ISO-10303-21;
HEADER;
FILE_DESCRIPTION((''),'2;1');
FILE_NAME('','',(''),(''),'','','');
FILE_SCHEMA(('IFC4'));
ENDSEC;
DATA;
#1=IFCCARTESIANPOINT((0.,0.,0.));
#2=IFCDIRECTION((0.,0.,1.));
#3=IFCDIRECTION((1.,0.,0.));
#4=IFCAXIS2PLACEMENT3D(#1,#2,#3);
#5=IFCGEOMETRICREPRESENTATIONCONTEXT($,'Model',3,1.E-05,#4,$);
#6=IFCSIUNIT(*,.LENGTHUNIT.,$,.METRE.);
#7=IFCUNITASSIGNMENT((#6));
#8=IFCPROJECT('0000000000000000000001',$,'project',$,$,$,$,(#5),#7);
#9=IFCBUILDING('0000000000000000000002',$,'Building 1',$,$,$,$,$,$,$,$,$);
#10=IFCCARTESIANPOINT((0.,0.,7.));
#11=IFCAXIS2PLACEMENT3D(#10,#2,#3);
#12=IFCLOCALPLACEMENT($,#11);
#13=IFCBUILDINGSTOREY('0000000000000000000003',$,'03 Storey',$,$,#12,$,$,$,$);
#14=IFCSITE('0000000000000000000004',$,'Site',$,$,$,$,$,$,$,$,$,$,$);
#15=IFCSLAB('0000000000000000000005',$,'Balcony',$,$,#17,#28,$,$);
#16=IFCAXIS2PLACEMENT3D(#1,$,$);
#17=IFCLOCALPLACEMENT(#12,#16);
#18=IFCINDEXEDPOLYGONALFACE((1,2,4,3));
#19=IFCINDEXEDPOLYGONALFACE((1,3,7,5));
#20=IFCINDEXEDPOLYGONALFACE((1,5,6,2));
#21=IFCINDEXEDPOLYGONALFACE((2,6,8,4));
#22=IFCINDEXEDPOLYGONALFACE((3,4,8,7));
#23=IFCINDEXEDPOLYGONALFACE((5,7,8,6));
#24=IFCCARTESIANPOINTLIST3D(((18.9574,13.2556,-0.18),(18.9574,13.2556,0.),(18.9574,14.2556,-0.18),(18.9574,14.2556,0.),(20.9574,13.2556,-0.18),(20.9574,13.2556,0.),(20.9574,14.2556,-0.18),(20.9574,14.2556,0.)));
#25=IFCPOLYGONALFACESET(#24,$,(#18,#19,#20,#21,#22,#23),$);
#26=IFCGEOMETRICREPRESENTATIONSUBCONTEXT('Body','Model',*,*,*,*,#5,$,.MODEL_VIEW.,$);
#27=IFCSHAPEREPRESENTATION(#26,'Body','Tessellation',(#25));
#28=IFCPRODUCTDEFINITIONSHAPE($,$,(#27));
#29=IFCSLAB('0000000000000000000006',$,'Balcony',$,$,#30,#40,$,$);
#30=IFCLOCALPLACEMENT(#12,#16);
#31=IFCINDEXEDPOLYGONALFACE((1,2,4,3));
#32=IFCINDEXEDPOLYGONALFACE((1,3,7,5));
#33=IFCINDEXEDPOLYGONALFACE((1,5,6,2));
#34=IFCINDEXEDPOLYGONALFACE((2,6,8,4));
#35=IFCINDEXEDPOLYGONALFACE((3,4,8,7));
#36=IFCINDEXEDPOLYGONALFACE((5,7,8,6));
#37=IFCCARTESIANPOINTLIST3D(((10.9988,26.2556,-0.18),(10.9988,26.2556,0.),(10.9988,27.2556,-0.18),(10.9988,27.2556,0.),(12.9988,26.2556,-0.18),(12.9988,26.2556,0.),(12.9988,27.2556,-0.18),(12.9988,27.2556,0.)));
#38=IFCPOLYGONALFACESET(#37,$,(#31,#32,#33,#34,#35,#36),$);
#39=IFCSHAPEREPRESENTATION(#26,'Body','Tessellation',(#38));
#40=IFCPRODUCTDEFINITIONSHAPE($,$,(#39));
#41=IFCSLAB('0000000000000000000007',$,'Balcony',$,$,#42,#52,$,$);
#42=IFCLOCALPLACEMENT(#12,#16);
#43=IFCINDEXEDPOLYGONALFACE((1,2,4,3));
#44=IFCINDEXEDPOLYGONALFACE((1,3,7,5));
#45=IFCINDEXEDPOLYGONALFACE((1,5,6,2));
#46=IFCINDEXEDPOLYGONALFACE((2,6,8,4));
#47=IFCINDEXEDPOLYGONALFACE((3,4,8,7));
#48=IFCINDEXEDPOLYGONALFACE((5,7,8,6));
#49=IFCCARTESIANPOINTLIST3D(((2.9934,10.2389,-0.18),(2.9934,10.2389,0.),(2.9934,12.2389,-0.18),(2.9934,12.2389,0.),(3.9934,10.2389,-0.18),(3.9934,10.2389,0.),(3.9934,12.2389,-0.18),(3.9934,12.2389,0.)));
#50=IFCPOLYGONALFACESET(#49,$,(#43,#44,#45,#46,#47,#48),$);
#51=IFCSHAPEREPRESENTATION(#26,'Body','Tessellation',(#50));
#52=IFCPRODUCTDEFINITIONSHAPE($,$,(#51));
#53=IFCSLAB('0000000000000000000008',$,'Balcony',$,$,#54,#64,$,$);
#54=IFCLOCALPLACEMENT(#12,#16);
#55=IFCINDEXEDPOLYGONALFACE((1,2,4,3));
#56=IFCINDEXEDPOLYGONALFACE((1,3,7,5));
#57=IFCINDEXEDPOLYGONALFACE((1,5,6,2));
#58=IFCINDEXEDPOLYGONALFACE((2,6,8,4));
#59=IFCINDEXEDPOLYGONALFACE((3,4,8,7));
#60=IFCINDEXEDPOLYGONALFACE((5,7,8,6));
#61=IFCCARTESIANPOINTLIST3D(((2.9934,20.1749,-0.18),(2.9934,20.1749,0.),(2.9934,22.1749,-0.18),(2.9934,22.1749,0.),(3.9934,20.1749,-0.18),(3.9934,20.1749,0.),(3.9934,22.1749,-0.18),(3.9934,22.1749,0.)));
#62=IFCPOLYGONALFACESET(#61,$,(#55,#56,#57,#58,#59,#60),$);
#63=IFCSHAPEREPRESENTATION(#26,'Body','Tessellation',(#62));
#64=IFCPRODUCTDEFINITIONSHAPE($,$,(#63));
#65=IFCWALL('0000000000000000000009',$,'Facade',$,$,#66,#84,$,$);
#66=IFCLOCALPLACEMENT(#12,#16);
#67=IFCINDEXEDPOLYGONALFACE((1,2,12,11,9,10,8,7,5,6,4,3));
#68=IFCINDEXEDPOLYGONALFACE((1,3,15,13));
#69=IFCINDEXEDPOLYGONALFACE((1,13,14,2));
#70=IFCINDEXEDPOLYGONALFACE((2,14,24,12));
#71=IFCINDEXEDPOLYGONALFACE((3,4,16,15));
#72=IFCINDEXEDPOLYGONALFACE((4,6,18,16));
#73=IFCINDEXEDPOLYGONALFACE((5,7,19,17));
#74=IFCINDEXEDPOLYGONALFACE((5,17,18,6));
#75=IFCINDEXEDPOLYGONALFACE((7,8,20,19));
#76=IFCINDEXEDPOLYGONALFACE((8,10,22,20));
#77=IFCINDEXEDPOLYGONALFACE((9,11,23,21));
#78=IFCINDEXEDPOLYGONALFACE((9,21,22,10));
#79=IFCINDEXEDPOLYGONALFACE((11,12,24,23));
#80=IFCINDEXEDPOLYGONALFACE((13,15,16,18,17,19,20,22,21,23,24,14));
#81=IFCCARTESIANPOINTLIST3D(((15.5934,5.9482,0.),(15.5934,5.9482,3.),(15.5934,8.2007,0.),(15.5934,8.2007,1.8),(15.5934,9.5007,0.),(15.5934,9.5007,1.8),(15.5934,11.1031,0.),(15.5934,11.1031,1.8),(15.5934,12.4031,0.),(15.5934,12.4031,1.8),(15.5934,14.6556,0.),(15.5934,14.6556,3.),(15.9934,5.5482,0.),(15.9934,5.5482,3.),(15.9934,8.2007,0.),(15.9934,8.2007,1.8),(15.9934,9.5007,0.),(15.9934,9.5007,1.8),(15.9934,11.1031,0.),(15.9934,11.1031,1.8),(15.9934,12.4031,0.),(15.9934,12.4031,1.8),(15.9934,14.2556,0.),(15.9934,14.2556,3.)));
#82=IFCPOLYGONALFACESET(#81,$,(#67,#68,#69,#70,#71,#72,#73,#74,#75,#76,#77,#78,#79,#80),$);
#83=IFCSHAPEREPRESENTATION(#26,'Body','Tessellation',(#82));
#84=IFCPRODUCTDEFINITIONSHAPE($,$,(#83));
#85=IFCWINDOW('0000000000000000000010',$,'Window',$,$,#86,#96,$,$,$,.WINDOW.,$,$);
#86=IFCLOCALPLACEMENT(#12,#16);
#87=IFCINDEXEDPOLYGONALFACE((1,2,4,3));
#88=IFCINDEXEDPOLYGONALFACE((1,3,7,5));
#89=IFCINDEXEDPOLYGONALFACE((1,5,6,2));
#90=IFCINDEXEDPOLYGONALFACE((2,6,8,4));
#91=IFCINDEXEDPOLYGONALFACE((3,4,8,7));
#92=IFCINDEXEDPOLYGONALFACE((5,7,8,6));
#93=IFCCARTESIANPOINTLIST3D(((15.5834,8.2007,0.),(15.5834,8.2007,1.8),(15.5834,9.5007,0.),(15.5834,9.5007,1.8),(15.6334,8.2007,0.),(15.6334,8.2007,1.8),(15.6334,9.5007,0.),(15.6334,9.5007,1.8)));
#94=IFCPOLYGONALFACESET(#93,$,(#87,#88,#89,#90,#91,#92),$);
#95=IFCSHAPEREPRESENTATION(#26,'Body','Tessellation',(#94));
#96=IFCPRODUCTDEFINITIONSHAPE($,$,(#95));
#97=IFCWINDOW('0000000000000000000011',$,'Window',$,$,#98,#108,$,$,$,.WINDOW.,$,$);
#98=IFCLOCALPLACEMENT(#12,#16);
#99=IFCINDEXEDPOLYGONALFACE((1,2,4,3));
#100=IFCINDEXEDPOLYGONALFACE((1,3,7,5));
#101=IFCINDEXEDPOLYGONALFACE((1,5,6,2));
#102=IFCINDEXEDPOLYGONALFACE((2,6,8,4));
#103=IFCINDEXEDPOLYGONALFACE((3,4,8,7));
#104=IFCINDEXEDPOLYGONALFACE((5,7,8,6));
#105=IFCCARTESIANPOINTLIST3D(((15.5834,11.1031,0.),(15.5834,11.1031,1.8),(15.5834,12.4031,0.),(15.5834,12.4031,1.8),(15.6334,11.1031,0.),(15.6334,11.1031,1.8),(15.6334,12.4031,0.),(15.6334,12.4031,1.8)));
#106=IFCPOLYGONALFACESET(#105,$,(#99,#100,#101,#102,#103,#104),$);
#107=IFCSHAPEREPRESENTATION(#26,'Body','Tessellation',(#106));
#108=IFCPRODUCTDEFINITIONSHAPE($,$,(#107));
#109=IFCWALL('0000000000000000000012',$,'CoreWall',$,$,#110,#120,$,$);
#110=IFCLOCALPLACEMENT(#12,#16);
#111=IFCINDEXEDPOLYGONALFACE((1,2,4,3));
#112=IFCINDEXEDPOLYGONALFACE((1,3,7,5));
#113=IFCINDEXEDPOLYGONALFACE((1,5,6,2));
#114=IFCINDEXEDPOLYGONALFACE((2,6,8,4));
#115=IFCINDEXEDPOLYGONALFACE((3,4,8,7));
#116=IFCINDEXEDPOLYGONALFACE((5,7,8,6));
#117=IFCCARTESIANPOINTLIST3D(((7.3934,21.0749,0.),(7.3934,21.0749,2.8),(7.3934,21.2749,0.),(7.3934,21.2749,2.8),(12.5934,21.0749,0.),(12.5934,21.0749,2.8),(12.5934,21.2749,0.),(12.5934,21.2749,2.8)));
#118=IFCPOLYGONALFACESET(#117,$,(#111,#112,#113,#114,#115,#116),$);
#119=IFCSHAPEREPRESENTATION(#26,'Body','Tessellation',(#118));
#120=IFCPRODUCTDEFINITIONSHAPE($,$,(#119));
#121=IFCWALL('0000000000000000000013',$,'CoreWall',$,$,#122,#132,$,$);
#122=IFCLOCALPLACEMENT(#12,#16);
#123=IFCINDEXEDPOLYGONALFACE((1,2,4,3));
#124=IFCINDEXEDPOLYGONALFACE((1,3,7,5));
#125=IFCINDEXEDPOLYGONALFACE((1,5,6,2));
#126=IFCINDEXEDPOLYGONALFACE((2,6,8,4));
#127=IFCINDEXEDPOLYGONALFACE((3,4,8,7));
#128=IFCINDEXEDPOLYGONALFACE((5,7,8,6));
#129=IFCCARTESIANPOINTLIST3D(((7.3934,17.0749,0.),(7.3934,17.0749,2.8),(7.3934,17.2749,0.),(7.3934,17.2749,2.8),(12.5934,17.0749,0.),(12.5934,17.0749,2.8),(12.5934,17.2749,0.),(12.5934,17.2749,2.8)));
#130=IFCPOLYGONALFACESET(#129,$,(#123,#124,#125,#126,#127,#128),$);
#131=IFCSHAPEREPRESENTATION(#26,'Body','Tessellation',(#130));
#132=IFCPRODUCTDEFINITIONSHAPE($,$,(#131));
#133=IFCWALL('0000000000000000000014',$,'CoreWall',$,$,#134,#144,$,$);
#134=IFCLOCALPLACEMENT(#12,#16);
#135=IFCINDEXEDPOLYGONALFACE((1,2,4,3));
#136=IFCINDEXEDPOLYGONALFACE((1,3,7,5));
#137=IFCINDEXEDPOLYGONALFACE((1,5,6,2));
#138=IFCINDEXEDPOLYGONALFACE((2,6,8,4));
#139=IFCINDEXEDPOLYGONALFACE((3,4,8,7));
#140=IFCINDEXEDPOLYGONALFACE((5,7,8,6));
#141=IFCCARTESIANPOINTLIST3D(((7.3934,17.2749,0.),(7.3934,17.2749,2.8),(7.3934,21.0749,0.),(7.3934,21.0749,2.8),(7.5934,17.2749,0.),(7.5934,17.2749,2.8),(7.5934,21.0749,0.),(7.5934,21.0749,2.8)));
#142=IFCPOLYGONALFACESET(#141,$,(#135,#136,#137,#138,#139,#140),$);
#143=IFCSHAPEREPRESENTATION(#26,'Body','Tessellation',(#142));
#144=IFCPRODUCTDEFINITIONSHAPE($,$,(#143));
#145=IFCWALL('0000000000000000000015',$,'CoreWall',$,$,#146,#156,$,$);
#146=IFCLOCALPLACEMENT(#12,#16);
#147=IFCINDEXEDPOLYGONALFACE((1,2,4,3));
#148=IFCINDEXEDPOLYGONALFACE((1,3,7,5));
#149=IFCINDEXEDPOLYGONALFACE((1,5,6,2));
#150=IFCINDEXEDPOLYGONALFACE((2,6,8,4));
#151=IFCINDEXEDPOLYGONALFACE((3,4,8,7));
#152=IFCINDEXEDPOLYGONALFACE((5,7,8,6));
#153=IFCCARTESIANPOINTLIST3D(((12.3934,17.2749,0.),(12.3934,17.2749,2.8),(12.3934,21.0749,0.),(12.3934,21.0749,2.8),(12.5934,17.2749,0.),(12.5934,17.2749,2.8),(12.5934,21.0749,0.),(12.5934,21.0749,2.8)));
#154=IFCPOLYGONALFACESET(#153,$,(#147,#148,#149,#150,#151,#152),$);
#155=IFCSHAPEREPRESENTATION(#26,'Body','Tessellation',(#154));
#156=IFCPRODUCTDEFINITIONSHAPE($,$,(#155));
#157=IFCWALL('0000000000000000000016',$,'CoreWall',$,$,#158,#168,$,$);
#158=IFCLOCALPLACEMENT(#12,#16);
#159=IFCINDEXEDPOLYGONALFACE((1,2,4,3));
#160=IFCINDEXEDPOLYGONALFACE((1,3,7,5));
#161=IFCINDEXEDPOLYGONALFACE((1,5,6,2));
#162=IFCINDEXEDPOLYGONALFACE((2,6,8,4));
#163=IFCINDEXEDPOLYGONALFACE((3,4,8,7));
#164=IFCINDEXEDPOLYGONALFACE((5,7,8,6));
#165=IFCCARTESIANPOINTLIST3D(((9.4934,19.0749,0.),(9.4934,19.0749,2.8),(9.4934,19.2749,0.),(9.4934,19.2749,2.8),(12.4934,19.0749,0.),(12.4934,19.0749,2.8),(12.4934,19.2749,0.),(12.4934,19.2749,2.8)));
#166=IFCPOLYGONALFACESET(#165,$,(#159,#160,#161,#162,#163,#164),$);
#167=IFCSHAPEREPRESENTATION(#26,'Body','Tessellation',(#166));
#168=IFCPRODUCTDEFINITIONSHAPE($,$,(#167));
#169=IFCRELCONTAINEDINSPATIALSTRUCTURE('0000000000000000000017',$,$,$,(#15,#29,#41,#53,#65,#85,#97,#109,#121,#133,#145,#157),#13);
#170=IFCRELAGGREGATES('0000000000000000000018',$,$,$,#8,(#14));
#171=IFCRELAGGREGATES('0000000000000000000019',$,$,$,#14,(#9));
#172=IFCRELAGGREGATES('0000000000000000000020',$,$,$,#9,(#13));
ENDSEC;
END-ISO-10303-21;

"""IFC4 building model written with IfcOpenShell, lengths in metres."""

from ifc_helpers import new_model, si_unit, frame, origin_with_axes, place, context, subcontext, project, spatial, line, indexed_curve, outline, extrude, element, fill, save


model = new_model("IFC4")

# Units and contexts
model_context = context("Model", 3, precision=1e-05, world=origin_with_axes())
body_context = subcontext(model_context, "Body", "Model", "MODEL_VIEW")
ifc_project = project(units=[si_unit("LENGTHUNIT", "METRE")], contexts=[model_context])

# Site, building, storey
site = spatial("IfcSite", under=ifc_project, Name="Site")
building = spatial("IfcBuilding", under=site, Name="Building 1")
storey_placement = place(None, frame((0.0, 0.0, 7.0), z_axis=(0.0, 0.0, 1.0), x_axis=(1.0, 0.0, 0.0)))
storey = spatial("IfcBuildingStorey", under=building, at=storey_placement, Name="03 Storey")

# Slabs
slab_1_placement = place(storey_placement, origin_with_axes())
element("IfcSlab", 1, at=slab_1_placement, inside=storey, Name="Balcony", context=body_context, shape_type="SweptSolid", body=[
    extrude(outline(indexed_curve([(20.9574, 14.2556), (20.9574, 13.2556), (18.9574, 13.2556), (18.9574, 14.2556)], segments=[line(1, 2), line(2, 3), line(3, 4)])), origin_with_axes(), (0.0, 0.0, -1.0), 0.18),
])
slab_2_placement = place(storey_placement, origin_with_axes())
element("IfcSlab", 2, at=slab_2_placement, inside=storey, Name="Balcony", context=body_context, shape_type="SweptSolid", body=[
    extrude(outline(indexed_curve([(10.9988, 26.2556), (10.9988, 27.2556), (12.9988, 27.2556), (12.9988, 26.2556)], segments=[line(1, 2), line(2, 3), line(3, 4)])), origin_with_axes(), (0.0, 0.0, -1.0), 0.18),
])
slab_3_placement = place(storey_placement, origin_with_axes())
element("IfcSlab", 3, at=slab_3_placement, inside=storey, Name="Balcony", context=body_context, shape_type="SweptSolid", body=[
    extrude(outline(indexed_curve([(3.9934, 10.2389), (2.9934, 10.2389), (2.9934, 12.2389), (3.9934, 12.2389)], segments=[line(1, 2), line(2, 3), line(3, 4)])), origin_with_axes(), (0.0, 0.0, -1.0), 0.18),
])
slab_4_placement = place(storey_placement, origin_with_axes())
element("IfcSlab", 4, at=slab_4_placement, inside=storey, Name="Balcony", context=body_context, shape_type="SweptSolid", body=[
    extrude(outline(indexed_curve([(3.9934, 20.1749), (2.9934, 20.1749), (2.9934, 22.1749), (3.9934, 22.1749)], segments=[line(1, 2), line(2, 3), line(3, 4)])), origin_with_axes(), (0.0, 0.0, -1.0), 0.18),
])

# Wall, openings, windows
wall_1_placement = place(storey_placement, origin_with_axes())
wall_1 = element("IfcWall", 5, at=wall_1_placement, inside=storey, Name="Facade", context=body_context, shape_type="SweptSolid", body=[
    extrude(outline(indexed_curve([(15.5934, 5.9482), (15.5934, 14.6556), (15.9934, 14.2556), (15.9934, 5.5482)], segments=[line(1, 2), line(2, 3), line(3, 4)])), origin_with_axes(), (0.0, 0.0, 1.0), 3.0),
])
opening_1_placement = place(wall_1_placement, origin_with_axes())
opening_1 = element("IfcOpeningElement", 6, at=opening_1_placement, cuts=wall_1, context=body_context, shape_type="SweptSolid", body=[
    extrude(outline(indexed_curve([(16.0334, 8.2007), (15.5334, 8.2007), (15.5334, 9.5007), (16.0334, 9.5007)], segments=[line(1, 2), line(2, 3), line(3, 4)])), origin_with_axes(), (0.0, 0.0, 1.0), 1.8),
])
opening_2_placement = place(wall_1_placement, origin_with_axes())
opening_2 = element("IfcOpeningElement", 7, at=opening_2_placement, cuts=wall_1, context=body_context, shape_type="SweptSolid", body=[
    extrude(outline(indexed_curve([(16.0334, 11.1031), (15.5334, 11.1031), (15.5334, 12.4031), (16.0334, 12.4031)], segments=[line(1, 2), line(2, 3), line(3, 4)])), origin_with_axes(), (0.0, 0.0, 1.0), 1.8),
])
window_1_placement = place(storey_placement, origin_with_axes())
window_1 = element("IfcWindow", 8, at=window_1_placement, inside=storey, Name="Window", PredefinedType="WINDOW", context=body_context, shape_type="SweptSolid", body=[
    extrude(outline(indexed_curve([(15.6334, 8.2007), (15.5834, 8.2007), (15.5834, 9.5007), (15.6334, 9.5007)], segments=[line(1, 2), line(2, 3), line(3, 4)])), origin_with_axes(), (0.0, 0.0, 1.0), 1.8),
])
fill(opening_1, window_1)
window_2_placement = place(storey_placement, origin_with_axes())
window_2 = element("IfcWindow", 9, at=window_2_placement, inside=storey, Name="Window", PredefinedType="WINDOW", context=body_context, shape_type="SweptSolid", body=[
    extrude(outline(indexed_curve([(15.6334, 11.1031), (15.5834, 11.1031), (15.5834, 12.4031), (15.6334, 12.4031)], segments=[line(1, 2), line(2, 3), line(3, 4)])), origin_with_axes(), (0.0, 0.0, 1.0), 1.8),
])
fill(opening_2, window_2)

# Walls
wall_2_placement = place(storey_placement, origin_with_axes())
element("IfcWall", 10, at=wall_2_placement, inside=storey, Name="CoreWall", context=body_context, shape_type="SweptSolid", body=[
    extrude(outline(indexed_curve([(12.5934, 21.2749), (7.3934, 21.2749), (7.3934, 21.0749), (12.5934, 21.0749)], segments=[line(1, 2), line(2, 3), line(3, 4)])), origin_with_axes(), (0.0, 0.0, 1.0), 2.8),
])
wall_3_placement = place(storey_placement, origin_with_axes())
element("IfcWall", 11, at=wall_3_placement, inside=storey, Name="CoreWall", context=body_context, shape_type="SweptSolid", body=[
    extrude(outline(indexed_curve([(7.3934, 17.0749), (12.5934, 17.0749), (12.5934, 17.2749), (7.3934, 17.2749)], segments=[line(1, 2), line(2, 3), line(3, 4)])), origin_with_axes(), (0.0, 0.0, 1.0), 2.8),
])
wall_4_placement = place(storey_placement, origin_with_axes())
element("IfcWall", 12, at=wall_4_placement, inside=storey, Name="CoreWall", context=body_context, shape_type="SweptSolid", body=[
    extrude(outline(indexed_curve([(7.5934, 17.2749), (7.5934, 21.0749), (7.3934, 21.0749), (7.3934, 17.2749)], segments=[line(1, 2), line(2, 3), line(3, 4)])), origin_with_axes(), (0.0, 0.0, 1.0), 2.8),
])
wall_5_placement = place(storey_placement, origin_with_axes())
element("IfcWall", 13, at=wall_5_placement, inside=storey, Name="CoreWall", context=body_context, shape_type="SweptSolid", body=[
    extrude(outline(indexed_curve([(12.3934, 21.0749), (12.3934, 17.2749), (12.5934, 17.2749), (12.5934, 21.0749)], segments=[line(1, 2), line(2, 3), line(3, 4)])), origin_with_axes(), (0.0, 0.0, 1.0), 2.8),
])
wall_6_placement = place(storey_placement, origin_with_axes())
element("IfcWall", 14, at=wall_6_placement, inside=storey, Name="CoreWall", context=body_context, shape_type="SweptSolid", body=[
    extrude(outline(indexed_curve([(12.4934, 19.2749), (9.4934, 19.2749), (9.4934, 19.0749), (12.4934, 19.0749)], segments=[line(1, 2), line(2, 3), line(3, 4)])), origin_with_axes(), (0.0, 0.0, 1.0), 2.8),
])

save(model, "model.ifc")
